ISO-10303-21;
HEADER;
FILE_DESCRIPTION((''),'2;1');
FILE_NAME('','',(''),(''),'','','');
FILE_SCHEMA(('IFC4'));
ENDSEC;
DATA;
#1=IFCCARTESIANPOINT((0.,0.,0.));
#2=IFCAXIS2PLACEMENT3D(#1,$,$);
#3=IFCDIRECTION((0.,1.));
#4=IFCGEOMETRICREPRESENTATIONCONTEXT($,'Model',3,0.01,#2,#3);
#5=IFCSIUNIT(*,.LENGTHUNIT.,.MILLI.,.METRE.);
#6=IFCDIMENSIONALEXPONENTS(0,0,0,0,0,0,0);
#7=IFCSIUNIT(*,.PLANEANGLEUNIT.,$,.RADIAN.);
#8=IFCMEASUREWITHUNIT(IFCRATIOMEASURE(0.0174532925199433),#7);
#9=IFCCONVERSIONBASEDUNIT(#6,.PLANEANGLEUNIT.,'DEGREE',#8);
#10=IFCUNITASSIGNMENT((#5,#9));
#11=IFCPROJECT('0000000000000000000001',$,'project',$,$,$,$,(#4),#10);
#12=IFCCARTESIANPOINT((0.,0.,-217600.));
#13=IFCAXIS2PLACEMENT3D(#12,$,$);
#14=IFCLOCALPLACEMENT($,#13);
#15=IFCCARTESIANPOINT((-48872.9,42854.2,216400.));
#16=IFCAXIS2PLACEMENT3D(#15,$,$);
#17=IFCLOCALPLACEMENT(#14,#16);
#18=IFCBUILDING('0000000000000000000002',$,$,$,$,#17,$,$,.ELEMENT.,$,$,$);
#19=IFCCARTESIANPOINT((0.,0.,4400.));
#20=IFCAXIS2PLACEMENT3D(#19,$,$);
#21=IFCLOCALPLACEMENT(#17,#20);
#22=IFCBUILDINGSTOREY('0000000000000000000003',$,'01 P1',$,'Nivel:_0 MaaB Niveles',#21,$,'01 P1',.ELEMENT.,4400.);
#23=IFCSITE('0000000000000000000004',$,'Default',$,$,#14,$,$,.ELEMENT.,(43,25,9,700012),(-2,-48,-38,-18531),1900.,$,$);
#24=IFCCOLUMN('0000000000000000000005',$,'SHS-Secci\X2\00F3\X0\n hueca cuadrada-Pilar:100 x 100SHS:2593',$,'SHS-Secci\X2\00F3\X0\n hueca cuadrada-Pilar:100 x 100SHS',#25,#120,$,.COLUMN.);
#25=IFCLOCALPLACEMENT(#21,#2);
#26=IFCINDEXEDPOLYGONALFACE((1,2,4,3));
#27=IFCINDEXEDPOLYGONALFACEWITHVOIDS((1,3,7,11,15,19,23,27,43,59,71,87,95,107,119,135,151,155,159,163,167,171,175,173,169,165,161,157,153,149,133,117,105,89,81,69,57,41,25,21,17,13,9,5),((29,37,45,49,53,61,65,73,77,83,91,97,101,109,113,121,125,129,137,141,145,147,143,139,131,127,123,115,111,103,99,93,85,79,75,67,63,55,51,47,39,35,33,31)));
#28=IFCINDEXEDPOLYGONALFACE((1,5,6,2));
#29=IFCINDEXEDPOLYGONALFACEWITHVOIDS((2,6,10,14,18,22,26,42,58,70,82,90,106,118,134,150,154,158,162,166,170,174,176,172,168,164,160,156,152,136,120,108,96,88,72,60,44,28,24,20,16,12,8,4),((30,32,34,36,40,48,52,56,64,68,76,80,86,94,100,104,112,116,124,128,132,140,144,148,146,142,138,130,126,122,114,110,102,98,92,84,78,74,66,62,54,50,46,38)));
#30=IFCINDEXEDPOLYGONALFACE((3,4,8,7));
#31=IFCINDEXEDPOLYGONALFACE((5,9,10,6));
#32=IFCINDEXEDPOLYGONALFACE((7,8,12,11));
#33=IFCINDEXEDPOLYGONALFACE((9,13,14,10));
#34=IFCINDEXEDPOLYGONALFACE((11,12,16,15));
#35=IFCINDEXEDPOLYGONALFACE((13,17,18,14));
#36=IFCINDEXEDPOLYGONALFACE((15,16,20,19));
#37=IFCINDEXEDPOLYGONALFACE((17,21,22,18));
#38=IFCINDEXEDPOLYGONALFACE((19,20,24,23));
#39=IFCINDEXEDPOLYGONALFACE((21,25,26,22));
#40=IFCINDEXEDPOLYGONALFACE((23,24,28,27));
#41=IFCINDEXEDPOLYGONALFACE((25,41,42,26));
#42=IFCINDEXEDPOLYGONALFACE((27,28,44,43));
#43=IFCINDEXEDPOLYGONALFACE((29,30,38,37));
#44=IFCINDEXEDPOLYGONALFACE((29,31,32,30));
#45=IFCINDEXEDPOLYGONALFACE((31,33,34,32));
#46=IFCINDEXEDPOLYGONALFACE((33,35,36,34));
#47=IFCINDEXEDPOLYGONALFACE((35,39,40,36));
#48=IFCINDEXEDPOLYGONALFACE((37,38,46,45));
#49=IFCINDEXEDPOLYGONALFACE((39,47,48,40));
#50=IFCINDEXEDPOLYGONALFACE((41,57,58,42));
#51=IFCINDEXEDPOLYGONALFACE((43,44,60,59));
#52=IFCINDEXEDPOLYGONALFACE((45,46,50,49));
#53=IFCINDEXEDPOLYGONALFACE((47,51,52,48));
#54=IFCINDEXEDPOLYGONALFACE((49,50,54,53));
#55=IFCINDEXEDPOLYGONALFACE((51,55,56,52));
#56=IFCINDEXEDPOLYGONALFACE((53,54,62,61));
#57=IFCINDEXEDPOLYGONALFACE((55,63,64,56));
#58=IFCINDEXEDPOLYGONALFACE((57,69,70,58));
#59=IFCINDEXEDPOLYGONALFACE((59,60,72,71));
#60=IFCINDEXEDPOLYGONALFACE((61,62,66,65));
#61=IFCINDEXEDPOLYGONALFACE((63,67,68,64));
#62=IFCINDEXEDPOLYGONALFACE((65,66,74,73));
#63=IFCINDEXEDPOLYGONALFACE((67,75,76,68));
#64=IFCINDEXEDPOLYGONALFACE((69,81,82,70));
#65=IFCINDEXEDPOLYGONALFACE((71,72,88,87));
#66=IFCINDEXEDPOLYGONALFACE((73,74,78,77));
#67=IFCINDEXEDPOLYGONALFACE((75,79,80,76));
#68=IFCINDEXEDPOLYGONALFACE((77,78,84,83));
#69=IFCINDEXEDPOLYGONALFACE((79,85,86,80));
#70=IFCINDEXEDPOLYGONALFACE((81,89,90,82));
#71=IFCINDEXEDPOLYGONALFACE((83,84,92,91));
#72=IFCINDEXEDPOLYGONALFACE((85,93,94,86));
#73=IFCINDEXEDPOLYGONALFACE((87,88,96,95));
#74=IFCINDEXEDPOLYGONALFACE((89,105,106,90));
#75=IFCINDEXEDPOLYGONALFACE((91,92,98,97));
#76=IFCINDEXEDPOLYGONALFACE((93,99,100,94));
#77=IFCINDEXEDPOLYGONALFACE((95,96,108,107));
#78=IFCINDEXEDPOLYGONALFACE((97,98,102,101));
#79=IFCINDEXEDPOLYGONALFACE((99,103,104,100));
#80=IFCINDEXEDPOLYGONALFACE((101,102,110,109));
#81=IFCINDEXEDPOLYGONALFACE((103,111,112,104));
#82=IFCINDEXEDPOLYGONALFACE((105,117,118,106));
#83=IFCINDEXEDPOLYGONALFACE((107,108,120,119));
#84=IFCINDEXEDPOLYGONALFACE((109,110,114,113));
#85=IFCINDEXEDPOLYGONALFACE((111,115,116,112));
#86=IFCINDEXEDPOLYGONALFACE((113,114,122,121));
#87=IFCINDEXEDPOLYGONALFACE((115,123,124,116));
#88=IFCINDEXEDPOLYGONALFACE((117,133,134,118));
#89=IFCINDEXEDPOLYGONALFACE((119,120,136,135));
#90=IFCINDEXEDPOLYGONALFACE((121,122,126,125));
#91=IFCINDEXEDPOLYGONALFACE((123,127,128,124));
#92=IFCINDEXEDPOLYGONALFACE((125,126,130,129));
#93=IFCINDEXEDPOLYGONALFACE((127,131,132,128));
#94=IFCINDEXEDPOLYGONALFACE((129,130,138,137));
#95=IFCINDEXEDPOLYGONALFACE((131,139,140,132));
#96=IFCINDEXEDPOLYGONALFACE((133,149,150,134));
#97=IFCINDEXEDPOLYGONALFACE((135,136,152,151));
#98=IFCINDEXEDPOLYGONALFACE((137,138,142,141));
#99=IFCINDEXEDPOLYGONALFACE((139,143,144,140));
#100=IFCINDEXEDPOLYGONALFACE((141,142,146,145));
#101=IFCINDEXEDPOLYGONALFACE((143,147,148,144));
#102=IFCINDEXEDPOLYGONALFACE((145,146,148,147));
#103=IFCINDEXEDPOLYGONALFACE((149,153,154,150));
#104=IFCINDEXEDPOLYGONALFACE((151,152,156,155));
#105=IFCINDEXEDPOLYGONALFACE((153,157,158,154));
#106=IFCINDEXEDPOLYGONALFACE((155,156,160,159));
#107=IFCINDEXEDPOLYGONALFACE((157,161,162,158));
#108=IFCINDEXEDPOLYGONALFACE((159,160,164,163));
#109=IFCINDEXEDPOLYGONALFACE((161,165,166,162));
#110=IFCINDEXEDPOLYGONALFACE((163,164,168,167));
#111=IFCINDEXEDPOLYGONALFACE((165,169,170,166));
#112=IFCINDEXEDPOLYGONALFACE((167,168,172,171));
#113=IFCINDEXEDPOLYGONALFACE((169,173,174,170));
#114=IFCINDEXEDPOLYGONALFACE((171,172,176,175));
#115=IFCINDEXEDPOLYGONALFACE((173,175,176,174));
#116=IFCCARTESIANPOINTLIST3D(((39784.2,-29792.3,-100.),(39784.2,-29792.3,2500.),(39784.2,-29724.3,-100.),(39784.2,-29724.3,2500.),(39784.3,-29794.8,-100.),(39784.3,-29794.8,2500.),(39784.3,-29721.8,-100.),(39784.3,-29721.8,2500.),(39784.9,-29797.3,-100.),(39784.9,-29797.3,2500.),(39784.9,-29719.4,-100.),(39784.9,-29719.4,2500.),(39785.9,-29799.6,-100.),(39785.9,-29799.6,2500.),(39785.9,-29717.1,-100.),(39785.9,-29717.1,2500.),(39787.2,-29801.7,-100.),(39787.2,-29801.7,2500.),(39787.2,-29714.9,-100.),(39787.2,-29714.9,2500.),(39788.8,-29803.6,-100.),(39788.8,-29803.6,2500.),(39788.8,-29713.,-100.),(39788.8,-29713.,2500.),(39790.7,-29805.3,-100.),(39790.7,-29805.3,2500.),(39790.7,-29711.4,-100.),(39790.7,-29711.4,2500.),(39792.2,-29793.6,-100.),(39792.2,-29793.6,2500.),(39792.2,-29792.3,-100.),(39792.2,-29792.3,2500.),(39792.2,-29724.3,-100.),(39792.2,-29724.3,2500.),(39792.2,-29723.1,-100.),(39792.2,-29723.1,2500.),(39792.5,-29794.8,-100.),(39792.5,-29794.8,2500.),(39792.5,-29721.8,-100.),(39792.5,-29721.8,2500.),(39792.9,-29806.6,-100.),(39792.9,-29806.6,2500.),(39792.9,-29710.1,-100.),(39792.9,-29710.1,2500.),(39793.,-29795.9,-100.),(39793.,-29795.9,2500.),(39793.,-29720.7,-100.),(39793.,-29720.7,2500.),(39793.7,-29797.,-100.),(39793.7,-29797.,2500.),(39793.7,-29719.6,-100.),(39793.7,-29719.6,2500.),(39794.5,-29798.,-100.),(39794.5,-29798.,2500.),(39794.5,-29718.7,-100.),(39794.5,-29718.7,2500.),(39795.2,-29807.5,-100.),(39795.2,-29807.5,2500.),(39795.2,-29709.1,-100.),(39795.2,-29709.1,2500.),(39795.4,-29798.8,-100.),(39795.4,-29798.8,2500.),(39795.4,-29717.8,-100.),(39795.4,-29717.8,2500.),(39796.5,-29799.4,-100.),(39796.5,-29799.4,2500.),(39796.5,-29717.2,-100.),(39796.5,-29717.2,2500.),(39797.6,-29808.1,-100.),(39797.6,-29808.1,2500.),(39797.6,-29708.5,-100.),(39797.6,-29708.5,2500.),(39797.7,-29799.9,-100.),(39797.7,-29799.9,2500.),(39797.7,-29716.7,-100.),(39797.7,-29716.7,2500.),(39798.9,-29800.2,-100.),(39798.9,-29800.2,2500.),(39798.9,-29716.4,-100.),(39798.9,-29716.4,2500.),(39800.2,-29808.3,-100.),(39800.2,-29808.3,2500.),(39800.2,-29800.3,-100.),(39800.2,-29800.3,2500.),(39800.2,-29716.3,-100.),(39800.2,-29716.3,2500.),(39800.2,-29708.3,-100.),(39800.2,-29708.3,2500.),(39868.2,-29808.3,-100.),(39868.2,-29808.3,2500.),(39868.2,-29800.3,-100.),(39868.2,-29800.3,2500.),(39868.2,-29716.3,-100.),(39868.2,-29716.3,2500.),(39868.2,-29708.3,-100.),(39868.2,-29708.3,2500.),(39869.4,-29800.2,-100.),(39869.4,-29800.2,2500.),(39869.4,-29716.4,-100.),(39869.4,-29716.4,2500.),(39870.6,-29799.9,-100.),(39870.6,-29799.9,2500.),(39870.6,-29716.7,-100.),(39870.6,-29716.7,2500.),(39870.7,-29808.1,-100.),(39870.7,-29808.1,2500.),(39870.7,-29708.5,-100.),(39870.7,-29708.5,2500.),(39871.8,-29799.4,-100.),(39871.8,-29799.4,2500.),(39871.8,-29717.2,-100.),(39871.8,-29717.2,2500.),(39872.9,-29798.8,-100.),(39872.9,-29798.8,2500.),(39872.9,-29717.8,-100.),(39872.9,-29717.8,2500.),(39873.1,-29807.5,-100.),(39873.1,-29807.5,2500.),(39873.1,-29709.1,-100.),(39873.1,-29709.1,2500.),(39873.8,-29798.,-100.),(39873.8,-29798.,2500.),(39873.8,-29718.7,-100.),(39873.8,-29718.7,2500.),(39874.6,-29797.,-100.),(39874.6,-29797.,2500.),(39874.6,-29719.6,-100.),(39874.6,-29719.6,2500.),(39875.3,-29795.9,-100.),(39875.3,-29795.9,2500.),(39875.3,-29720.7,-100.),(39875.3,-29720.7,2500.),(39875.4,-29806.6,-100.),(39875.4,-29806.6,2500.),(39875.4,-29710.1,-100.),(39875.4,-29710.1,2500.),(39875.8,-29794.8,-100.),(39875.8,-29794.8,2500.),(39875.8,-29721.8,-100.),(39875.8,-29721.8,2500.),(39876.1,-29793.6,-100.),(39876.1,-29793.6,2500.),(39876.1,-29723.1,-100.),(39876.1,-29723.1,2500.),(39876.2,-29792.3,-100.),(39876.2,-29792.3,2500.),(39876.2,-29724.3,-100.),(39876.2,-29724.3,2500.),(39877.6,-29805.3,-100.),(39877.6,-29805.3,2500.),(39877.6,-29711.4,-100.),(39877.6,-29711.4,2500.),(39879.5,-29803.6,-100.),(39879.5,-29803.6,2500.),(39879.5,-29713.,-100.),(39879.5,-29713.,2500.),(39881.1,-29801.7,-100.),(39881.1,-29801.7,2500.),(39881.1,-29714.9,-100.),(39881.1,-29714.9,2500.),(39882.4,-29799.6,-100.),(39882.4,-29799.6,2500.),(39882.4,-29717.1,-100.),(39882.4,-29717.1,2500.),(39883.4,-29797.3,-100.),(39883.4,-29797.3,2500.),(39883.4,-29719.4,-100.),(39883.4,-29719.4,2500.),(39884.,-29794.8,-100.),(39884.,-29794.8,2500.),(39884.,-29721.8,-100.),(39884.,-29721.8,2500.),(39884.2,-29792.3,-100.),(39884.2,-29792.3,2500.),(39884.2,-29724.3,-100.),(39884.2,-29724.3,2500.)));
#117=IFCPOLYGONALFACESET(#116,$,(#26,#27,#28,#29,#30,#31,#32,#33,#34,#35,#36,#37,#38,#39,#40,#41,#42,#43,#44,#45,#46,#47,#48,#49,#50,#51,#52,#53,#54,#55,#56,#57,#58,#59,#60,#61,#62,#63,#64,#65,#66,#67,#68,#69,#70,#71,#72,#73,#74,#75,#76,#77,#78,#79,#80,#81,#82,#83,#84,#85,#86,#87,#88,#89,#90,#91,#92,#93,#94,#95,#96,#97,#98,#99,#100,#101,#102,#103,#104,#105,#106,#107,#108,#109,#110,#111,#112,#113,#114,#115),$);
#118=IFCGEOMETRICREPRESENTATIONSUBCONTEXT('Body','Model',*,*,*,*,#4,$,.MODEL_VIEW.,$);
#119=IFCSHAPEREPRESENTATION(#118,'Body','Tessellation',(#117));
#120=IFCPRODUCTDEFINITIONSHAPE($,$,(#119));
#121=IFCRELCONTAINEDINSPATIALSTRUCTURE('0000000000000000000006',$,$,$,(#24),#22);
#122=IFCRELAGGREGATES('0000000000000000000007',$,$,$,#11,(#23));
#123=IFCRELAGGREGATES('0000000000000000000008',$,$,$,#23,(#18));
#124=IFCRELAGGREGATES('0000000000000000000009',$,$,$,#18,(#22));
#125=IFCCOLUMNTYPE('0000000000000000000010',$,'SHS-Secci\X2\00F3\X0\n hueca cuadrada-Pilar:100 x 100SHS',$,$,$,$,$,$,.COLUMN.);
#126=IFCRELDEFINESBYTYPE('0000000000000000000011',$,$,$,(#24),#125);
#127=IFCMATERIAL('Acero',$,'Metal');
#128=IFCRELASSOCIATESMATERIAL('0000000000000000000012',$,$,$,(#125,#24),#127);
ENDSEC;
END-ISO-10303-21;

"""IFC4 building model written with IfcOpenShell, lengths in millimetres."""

from ifc_helpers import new_model, entity, si_unit, converted_unit, direction, frame, origin, place, context, subcontext, project, spatial, indexed_curve, outline, extrude, source, transform, mapped, material, type_object, type_shapes, element, save


model = new_model("IFC4")

# Units and contexts
model_context = context("Model", 3, precision=0.01, world=origin(), true_north=direction((0.0, 1.0)))
body_context = subcontext(model_context, "Body", "Model", "MODEL_VIEW")
ifc_project = project(units=[si_unit("LENGTHUNIT", "METRE", prefix="MILLI"), converted_unit("PLANEANGLEUNIT", "DEGREE", entity("IfcRatioMeasure", 0.0174532925199433), si_unit("PLANEANGLEUNIT", "RADIAN"), dimensions=[0, 0, 0, 0, 0, 0, 0])], contexts=[model_context])

# Site, building, storey
site_placement = place(None, frame((0.0, 0.0, -217600.0)))
site = spatial("IfcSite", under=ifc_project, at=site_placement, Name="Default", CompositionType="ELEMENT", RefLatitude=(43, 25, 9, 700012), RefLongitude=(-2, -48, -38, -18531), RefElevation=1900.0)
building_placement = place(site_placement, frame((-48872.9, 42854.2, 216400.0)))
building = spatial("IfcBuilding", under=site, at=building_placement, CompositionType="ELEMENT")
storey_placement = place(building_placement, frame((0.0, 0.0, 4400.0)))
storey = spatial("IfcBuildingStorey", under=building, at=storey_placement, Name="01 P1", ObjectType="Nivel:_0 MaaB Niveles", LongName="01 P1", CompositionType="ELEMENT", Elevation=4400.0)

# Column
ifc_material_1 = material(Name="Acero", Category="Metal")
column_type_1 = type_object("IfcColumnType", Name="SHS-Sección hueca cuadrada-Pilar:100 x 100SHS", PredefinedType="COLUMN", material=ifc_material_1)
shared_shape_1 = source(origin(), body_context, "Body", "SweptSolid", [
    extrude(outline(indexed_curve([(-34.0, -50.0), (34.0, -50.0), (36.5, -49.8), (38.9, -49.2), (41.3, -48.3), (43.4, -46.9), (45.3, -45.3), (46.9, -43.4), (48.3, -41.3), (49.2, -38.9), (49.8, -36.5), (50.0, -34.0), (50.0, 34.0), (49.8, 36.5), (49.2, 38.9), (48.3, 41.3), (46.9, 43.4), (45.3, 45.3), (43.4, 46.9), (41.3, 48.3), (38.9, 49.2), (36.5, 49.8), (34.0, 50.0), (-34.0, 50.0), (-36.5, 49.8), (-38.9, 49.2), (-41.3, 48.3), (-43.4, 46.9), (-45.3, 45.3), (-46.9, 43.4), (-48.3, 41.3), (-49.2, 38.9), (-49.8, 36.5), (-50.0, 34.0), (-50.0, -34.0), (-49.8, -36.5), (-49.2, -38.9), (-48.3, -41.3), (-46.9, -43.4), (-45.3, -45.3), (-43.4, -46.9), (-41.3, -48.3), (-38.9, -49.2), (-36.5, -49.8), (-34.0, -50.0)], self_intersect=False), holes=[indexed_curve([(-34.0, -42.0), (-35.3, -41.9), (-36.5, -41.6), (-37.6, -41.1), (-38.7, -40.5), (-39.7, -39.7), (-40.5, -38.7), (-41.1, -37.6), (-41.6, -36.5), (-41.9, -35.3), (-42.0, -34.0), (-42.0, 34.0), (-41.9, 35.3), (-41.6, 36.5), (-41.1, 37.6), (-40.5, 38.7), (-39.7, 39.7), (-38.7, 40.5), (-37.6, 41.1), (-36.5, 41.6), (-35.3, 41.9), (-34.0, 42.0), (34.0, 42.0), (35.3, 41.9), (36.5, 41.6), (37.6, 41.1), (38.7, 40.5), (39.7, 39.7), (40.5, 38.7), (41.1, 37.6), (41.6, 36.5), (41.9, 35.3), (42.0, 34.0), (42.0, -34.0), (41.9, -35.3), (41.6, -36.5), (41.1, -37.6), (40.5, -38.7), (39.7, -39.7), (38.7, -40.5), (37.6, -41.1), (36.5, -41.6), (35.3, -41.9), (34.0, -42.0), (-34.0, -42.0)], self_intersect=False)]), frame((0.0, 0.0, 4300.0), z_axis=(0.0, 0.0, 1.0), x_axis=(-1.0, 0.0, 0.0)), (0.0, 0.0, 1.0), 2600.0),
])
type_shapes(column_type_1, [shared_shape_1])
column_1_placement = place(storey_placement, frame((39834.2, -29758.3, -4400.0), z_axis=(0.0, 0.0, 1.0), x_axis=(0.0, -1.0, 0.0)))
element("IfcColumn", 1, at=column_1_placement, inside=storey, type_object=column_type_1, material=ifc_material_1, Name="SHS-Sección hueca cuadrada-Pilar:100 x 100SHS:2593", ObjectType="SHS-Sección hueca cuadrada-Pilar:100 x 100SHS", PredefinedType="COLUMN", context=body_context, shape_type="MappedRepresentation", body=[
    mapped(shared_shape_1, transform((0.0, 0.0, 0.0), scale=1.0)),
])

save(model, "model.ifc")
